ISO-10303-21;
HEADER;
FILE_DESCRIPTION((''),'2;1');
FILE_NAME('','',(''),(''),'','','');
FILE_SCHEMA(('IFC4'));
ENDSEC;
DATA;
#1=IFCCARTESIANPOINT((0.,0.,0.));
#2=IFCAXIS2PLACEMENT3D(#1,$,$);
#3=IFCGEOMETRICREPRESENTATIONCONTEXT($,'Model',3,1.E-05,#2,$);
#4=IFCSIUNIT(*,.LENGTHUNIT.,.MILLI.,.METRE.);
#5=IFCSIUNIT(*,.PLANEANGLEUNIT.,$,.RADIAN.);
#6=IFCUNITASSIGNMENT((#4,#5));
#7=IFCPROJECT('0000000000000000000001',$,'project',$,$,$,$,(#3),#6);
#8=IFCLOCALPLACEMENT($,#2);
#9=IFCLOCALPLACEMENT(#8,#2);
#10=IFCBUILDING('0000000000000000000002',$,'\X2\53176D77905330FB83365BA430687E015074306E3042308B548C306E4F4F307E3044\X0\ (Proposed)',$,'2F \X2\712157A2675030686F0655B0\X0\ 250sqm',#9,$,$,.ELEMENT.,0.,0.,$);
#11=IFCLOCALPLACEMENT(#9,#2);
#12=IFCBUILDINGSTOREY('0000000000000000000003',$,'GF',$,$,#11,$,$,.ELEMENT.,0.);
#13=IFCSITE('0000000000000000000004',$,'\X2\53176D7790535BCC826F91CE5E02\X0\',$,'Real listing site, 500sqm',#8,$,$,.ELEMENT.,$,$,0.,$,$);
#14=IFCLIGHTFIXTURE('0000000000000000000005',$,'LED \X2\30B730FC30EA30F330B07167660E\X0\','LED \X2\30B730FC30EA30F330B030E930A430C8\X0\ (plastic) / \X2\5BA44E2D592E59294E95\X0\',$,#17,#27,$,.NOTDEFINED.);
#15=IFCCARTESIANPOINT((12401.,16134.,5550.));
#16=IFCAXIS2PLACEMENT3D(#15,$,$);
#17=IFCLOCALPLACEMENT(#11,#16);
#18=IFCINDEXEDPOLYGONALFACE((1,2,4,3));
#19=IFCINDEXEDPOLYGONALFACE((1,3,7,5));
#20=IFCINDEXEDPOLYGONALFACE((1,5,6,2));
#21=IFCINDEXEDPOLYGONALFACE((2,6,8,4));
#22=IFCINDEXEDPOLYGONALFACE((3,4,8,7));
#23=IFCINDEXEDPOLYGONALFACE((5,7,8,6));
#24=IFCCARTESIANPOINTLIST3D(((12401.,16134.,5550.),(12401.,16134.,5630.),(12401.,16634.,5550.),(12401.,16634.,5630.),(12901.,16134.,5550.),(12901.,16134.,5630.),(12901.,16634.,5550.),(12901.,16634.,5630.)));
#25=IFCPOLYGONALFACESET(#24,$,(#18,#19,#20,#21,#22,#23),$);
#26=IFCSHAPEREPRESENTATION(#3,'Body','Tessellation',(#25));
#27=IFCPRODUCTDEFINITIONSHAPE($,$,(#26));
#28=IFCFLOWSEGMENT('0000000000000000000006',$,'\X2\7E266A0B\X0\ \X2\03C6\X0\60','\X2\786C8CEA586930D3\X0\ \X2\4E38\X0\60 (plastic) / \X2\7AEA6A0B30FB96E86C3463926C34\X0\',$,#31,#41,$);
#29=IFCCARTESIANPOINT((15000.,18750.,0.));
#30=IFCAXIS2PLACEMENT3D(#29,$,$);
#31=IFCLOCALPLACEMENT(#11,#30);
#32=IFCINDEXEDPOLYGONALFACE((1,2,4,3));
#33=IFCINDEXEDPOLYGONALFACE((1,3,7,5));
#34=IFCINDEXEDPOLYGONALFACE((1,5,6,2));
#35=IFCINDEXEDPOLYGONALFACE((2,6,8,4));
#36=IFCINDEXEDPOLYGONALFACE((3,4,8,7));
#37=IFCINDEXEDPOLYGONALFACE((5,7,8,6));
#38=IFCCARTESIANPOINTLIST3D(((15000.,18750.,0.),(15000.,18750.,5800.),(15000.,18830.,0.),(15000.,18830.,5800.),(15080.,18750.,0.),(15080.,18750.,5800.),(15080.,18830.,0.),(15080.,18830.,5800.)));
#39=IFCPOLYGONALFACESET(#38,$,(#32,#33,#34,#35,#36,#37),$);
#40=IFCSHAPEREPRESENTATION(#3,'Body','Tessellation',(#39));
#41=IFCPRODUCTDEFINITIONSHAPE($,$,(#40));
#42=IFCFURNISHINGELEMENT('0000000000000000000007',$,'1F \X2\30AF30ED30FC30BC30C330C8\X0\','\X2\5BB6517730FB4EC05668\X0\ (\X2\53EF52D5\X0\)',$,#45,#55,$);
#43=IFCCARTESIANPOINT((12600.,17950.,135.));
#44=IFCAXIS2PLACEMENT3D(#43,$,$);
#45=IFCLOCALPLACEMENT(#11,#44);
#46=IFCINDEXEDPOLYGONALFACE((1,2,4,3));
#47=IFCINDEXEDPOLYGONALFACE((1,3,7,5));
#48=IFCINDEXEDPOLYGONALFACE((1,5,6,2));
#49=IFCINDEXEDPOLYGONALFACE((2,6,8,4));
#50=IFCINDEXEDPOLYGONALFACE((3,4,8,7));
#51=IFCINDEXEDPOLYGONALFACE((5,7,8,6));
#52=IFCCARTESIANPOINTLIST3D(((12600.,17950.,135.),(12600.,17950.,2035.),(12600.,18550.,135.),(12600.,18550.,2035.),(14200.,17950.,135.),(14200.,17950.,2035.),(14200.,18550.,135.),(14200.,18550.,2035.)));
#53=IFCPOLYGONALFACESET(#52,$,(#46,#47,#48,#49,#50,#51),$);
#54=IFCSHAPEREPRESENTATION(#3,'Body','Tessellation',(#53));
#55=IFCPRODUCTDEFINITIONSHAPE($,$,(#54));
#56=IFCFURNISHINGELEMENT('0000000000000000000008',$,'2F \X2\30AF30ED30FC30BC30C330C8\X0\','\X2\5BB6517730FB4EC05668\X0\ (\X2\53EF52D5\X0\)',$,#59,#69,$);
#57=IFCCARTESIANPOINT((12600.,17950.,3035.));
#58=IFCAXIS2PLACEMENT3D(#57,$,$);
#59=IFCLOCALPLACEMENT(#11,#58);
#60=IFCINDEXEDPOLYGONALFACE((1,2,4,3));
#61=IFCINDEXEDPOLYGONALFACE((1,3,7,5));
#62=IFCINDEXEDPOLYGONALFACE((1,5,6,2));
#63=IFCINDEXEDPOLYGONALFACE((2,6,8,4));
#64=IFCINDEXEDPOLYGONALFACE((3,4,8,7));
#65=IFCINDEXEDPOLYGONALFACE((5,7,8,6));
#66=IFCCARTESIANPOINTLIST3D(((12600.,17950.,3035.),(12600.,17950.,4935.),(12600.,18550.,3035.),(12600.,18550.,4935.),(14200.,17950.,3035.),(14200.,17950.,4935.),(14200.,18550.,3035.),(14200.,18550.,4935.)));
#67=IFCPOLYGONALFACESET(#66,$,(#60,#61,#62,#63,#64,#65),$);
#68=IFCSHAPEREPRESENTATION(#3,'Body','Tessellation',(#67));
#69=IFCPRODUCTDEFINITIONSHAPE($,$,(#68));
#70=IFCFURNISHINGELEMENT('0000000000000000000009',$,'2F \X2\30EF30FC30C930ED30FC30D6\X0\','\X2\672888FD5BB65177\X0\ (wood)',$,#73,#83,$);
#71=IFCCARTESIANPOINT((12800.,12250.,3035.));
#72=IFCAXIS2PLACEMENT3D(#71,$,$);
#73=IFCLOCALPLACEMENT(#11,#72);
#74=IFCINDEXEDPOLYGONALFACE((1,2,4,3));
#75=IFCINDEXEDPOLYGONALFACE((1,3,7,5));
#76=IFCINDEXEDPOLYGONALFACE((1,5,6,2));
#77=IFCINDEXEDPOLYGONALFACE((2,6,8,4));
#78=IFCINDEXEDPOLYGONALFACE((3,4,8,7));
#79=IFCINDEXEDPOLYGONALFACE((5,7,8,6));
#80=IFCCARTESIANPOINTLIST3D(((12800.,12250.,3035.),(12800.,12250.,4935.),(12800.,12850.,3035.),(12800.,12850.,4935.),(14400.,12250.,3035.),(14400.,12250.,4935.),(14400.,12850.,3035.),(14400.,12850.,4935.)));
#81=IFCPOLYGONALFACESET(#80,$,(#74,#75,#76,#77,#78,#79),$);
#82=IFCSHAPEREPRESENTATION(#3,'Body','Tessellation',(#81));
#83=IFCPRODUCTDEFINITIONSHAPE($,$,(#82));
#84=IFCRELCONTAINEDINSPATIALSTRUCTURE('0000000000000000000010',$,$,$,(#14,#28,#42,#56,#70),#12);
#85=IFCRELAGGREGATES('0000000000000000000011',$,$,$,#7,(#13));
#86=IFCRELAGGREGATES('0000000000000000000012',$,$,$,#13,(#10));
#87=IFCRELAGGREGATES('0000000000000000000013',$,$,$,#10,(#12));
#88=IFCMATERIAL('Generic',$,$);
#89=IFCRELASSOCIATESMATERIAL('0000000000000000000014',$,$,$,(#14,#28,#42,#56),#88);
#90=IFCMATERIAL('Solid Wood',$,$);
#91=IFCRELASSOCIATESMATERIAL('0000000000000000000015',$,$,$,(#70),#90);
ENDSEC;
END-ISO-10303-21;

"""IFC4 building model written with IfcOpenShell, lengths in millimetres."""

from ifc_helpers import new_model, si_unit, frame, frame_2d, origin, place, context, project, spatial, rectangle, extrude, material, element, save


model = new_model("IFC4")

# Units and contexts
model_context = context("Model", 3, precision=1e-05, world=origin())
ifc_project = project(units=[si_unit("LENGTHUNIT", "METRE", prefix="MILLI"), si_unit("PLANEANGLEUNIT", "RADIAN")], contexts=[model_context])

# Site, building, storey
site_placement = place(None, origin())
site = spatial("IfcSite", under=ifc_project, at=site_placement, Name="北海道富良野市", ObjectType="Real listing site, 500sqm", CompositionType="ELEMENT", RefElevation=0.0)
building_placement = place(site_placement, origin())
building = spatial("IfcBuilding", under=site, at=building_placement, Name="北海道・茶室と縁側のある和の住まい (Proposed)", ObjectType="2F 無垢材と漆喰 250sqm", CompositionType="ELEMENT", ElevationOfRefHeight=0.0, ElevationOfTerrain=0.0)
storey_placement = place(building_placement, origin())
storey = spatial("IfcBuildingStorey", under=building, at=storey_placement, Name="GF", CompositionType="ELEMENT", Elevation=0.0)

# Shared definitions
ifc_material_1 = material(Name="Solid Wood")

# Shared definitions
ifc_material_2 = material(Name="Generic")

# Light fixture
light_fixture_1_placement = place(storey_placement, frame((12401.0, 16134.0, 5550.0)))
element("IfcLightFixture", 1, at=light_fixture_1_placement, inside=storey, material=ifc_material_2, Name="LED シーリング照明", Description="LED シーリングライト (plastic) / 室中央天井", PredefinedType="NOTDEFINED", context=model_context, shape_type="SweptSolid", body=[
    extrude(rectangle(XDim=500.0, YDim=500.0, at=frame_2d((250.0, 250.0))), frame((12401.0, 16134.0, 5550.0)), (0.0, 0.0, 1.0), 80.0),
])

# Flow segment
flow_segment_placement = place(storey_placement, frame((15000.0, 18750.0, 0.0)))
element("IfcFlowSegment", 2, at=flow_segment_placement, inside=storey, material=ifc_material_2, Name="縦樋 φ60", Description="硬質塩ビ 丸60 (plastic) / 竪樋・雨水排水", context=model_context, shape_type="SweptSolid", body=[
    extrude(rectangle(XDim=80.0, YDim=80.0, at=frame_2d((40.0, 40.0))), frame((15000.0, 18750.0, 0.0)), (0.0, 0.0, 1.0), 5800.0),
])

# Furnishing elements
furnishing_1_placement = place(storey_placement, frame((12600.0, 17950.0, 135.0)))
element("IfcFurnishingElement", 3, at=furnishing_1_placement, inside=storey, material=ifc_material_2, Name="1F クローゼット", Description="家具・什器 (可動)", context=model_context, shape_type="SweptSolid", body=[
    extrude(rectangle(XDim=1600.0, YDim=600.0, at=frame_2d((800.0, 300.0))), frame((12600.0, 17950.0, 135.0)), (0.0, 0.0, 1.0), 1900.0),
])
furnishing_2_placement = place(storey_placement, frame((12600.0, 17950.0, 3035.0)))
element("IfcFurnishingElement", 4, at=furnishing_2_placement, inside=storey, material=ifc_material_2, Name="2F クローゼット", Description="家具・什器 (可動)", context=model_context, shape_type="SweptSolid", body=[
    extrude(rectangle(XDim=1600.0, YDim=600.0, at=frame_2d((800.0, 300.0))), frame((12600.0, 17950.0, 3035.0)), (0.0, 0.0, 1.0), 1900.0),
])
furnishing_3_placement = place(storey_placement, frame((12800.0, 12250.0, 3035.0)))
element("IfcFurnishingElement", 5, at=furnishing_3_placement, inside=storey, material=ifc_material_1, Name="2F ワードローブ", Description="木製家具 (wood)", context=model_context, shape_type="SweptSolid", body=[
    extrude(rectangle(XDim=1600.0, YDim=600.0, at=frame_2d((800.0, 300.0))), frame((12800.0, 12250.0, 3035.0)), (0.0, 0.0, 1.0), 1900.0),
])

save(model, "model.ifc")
